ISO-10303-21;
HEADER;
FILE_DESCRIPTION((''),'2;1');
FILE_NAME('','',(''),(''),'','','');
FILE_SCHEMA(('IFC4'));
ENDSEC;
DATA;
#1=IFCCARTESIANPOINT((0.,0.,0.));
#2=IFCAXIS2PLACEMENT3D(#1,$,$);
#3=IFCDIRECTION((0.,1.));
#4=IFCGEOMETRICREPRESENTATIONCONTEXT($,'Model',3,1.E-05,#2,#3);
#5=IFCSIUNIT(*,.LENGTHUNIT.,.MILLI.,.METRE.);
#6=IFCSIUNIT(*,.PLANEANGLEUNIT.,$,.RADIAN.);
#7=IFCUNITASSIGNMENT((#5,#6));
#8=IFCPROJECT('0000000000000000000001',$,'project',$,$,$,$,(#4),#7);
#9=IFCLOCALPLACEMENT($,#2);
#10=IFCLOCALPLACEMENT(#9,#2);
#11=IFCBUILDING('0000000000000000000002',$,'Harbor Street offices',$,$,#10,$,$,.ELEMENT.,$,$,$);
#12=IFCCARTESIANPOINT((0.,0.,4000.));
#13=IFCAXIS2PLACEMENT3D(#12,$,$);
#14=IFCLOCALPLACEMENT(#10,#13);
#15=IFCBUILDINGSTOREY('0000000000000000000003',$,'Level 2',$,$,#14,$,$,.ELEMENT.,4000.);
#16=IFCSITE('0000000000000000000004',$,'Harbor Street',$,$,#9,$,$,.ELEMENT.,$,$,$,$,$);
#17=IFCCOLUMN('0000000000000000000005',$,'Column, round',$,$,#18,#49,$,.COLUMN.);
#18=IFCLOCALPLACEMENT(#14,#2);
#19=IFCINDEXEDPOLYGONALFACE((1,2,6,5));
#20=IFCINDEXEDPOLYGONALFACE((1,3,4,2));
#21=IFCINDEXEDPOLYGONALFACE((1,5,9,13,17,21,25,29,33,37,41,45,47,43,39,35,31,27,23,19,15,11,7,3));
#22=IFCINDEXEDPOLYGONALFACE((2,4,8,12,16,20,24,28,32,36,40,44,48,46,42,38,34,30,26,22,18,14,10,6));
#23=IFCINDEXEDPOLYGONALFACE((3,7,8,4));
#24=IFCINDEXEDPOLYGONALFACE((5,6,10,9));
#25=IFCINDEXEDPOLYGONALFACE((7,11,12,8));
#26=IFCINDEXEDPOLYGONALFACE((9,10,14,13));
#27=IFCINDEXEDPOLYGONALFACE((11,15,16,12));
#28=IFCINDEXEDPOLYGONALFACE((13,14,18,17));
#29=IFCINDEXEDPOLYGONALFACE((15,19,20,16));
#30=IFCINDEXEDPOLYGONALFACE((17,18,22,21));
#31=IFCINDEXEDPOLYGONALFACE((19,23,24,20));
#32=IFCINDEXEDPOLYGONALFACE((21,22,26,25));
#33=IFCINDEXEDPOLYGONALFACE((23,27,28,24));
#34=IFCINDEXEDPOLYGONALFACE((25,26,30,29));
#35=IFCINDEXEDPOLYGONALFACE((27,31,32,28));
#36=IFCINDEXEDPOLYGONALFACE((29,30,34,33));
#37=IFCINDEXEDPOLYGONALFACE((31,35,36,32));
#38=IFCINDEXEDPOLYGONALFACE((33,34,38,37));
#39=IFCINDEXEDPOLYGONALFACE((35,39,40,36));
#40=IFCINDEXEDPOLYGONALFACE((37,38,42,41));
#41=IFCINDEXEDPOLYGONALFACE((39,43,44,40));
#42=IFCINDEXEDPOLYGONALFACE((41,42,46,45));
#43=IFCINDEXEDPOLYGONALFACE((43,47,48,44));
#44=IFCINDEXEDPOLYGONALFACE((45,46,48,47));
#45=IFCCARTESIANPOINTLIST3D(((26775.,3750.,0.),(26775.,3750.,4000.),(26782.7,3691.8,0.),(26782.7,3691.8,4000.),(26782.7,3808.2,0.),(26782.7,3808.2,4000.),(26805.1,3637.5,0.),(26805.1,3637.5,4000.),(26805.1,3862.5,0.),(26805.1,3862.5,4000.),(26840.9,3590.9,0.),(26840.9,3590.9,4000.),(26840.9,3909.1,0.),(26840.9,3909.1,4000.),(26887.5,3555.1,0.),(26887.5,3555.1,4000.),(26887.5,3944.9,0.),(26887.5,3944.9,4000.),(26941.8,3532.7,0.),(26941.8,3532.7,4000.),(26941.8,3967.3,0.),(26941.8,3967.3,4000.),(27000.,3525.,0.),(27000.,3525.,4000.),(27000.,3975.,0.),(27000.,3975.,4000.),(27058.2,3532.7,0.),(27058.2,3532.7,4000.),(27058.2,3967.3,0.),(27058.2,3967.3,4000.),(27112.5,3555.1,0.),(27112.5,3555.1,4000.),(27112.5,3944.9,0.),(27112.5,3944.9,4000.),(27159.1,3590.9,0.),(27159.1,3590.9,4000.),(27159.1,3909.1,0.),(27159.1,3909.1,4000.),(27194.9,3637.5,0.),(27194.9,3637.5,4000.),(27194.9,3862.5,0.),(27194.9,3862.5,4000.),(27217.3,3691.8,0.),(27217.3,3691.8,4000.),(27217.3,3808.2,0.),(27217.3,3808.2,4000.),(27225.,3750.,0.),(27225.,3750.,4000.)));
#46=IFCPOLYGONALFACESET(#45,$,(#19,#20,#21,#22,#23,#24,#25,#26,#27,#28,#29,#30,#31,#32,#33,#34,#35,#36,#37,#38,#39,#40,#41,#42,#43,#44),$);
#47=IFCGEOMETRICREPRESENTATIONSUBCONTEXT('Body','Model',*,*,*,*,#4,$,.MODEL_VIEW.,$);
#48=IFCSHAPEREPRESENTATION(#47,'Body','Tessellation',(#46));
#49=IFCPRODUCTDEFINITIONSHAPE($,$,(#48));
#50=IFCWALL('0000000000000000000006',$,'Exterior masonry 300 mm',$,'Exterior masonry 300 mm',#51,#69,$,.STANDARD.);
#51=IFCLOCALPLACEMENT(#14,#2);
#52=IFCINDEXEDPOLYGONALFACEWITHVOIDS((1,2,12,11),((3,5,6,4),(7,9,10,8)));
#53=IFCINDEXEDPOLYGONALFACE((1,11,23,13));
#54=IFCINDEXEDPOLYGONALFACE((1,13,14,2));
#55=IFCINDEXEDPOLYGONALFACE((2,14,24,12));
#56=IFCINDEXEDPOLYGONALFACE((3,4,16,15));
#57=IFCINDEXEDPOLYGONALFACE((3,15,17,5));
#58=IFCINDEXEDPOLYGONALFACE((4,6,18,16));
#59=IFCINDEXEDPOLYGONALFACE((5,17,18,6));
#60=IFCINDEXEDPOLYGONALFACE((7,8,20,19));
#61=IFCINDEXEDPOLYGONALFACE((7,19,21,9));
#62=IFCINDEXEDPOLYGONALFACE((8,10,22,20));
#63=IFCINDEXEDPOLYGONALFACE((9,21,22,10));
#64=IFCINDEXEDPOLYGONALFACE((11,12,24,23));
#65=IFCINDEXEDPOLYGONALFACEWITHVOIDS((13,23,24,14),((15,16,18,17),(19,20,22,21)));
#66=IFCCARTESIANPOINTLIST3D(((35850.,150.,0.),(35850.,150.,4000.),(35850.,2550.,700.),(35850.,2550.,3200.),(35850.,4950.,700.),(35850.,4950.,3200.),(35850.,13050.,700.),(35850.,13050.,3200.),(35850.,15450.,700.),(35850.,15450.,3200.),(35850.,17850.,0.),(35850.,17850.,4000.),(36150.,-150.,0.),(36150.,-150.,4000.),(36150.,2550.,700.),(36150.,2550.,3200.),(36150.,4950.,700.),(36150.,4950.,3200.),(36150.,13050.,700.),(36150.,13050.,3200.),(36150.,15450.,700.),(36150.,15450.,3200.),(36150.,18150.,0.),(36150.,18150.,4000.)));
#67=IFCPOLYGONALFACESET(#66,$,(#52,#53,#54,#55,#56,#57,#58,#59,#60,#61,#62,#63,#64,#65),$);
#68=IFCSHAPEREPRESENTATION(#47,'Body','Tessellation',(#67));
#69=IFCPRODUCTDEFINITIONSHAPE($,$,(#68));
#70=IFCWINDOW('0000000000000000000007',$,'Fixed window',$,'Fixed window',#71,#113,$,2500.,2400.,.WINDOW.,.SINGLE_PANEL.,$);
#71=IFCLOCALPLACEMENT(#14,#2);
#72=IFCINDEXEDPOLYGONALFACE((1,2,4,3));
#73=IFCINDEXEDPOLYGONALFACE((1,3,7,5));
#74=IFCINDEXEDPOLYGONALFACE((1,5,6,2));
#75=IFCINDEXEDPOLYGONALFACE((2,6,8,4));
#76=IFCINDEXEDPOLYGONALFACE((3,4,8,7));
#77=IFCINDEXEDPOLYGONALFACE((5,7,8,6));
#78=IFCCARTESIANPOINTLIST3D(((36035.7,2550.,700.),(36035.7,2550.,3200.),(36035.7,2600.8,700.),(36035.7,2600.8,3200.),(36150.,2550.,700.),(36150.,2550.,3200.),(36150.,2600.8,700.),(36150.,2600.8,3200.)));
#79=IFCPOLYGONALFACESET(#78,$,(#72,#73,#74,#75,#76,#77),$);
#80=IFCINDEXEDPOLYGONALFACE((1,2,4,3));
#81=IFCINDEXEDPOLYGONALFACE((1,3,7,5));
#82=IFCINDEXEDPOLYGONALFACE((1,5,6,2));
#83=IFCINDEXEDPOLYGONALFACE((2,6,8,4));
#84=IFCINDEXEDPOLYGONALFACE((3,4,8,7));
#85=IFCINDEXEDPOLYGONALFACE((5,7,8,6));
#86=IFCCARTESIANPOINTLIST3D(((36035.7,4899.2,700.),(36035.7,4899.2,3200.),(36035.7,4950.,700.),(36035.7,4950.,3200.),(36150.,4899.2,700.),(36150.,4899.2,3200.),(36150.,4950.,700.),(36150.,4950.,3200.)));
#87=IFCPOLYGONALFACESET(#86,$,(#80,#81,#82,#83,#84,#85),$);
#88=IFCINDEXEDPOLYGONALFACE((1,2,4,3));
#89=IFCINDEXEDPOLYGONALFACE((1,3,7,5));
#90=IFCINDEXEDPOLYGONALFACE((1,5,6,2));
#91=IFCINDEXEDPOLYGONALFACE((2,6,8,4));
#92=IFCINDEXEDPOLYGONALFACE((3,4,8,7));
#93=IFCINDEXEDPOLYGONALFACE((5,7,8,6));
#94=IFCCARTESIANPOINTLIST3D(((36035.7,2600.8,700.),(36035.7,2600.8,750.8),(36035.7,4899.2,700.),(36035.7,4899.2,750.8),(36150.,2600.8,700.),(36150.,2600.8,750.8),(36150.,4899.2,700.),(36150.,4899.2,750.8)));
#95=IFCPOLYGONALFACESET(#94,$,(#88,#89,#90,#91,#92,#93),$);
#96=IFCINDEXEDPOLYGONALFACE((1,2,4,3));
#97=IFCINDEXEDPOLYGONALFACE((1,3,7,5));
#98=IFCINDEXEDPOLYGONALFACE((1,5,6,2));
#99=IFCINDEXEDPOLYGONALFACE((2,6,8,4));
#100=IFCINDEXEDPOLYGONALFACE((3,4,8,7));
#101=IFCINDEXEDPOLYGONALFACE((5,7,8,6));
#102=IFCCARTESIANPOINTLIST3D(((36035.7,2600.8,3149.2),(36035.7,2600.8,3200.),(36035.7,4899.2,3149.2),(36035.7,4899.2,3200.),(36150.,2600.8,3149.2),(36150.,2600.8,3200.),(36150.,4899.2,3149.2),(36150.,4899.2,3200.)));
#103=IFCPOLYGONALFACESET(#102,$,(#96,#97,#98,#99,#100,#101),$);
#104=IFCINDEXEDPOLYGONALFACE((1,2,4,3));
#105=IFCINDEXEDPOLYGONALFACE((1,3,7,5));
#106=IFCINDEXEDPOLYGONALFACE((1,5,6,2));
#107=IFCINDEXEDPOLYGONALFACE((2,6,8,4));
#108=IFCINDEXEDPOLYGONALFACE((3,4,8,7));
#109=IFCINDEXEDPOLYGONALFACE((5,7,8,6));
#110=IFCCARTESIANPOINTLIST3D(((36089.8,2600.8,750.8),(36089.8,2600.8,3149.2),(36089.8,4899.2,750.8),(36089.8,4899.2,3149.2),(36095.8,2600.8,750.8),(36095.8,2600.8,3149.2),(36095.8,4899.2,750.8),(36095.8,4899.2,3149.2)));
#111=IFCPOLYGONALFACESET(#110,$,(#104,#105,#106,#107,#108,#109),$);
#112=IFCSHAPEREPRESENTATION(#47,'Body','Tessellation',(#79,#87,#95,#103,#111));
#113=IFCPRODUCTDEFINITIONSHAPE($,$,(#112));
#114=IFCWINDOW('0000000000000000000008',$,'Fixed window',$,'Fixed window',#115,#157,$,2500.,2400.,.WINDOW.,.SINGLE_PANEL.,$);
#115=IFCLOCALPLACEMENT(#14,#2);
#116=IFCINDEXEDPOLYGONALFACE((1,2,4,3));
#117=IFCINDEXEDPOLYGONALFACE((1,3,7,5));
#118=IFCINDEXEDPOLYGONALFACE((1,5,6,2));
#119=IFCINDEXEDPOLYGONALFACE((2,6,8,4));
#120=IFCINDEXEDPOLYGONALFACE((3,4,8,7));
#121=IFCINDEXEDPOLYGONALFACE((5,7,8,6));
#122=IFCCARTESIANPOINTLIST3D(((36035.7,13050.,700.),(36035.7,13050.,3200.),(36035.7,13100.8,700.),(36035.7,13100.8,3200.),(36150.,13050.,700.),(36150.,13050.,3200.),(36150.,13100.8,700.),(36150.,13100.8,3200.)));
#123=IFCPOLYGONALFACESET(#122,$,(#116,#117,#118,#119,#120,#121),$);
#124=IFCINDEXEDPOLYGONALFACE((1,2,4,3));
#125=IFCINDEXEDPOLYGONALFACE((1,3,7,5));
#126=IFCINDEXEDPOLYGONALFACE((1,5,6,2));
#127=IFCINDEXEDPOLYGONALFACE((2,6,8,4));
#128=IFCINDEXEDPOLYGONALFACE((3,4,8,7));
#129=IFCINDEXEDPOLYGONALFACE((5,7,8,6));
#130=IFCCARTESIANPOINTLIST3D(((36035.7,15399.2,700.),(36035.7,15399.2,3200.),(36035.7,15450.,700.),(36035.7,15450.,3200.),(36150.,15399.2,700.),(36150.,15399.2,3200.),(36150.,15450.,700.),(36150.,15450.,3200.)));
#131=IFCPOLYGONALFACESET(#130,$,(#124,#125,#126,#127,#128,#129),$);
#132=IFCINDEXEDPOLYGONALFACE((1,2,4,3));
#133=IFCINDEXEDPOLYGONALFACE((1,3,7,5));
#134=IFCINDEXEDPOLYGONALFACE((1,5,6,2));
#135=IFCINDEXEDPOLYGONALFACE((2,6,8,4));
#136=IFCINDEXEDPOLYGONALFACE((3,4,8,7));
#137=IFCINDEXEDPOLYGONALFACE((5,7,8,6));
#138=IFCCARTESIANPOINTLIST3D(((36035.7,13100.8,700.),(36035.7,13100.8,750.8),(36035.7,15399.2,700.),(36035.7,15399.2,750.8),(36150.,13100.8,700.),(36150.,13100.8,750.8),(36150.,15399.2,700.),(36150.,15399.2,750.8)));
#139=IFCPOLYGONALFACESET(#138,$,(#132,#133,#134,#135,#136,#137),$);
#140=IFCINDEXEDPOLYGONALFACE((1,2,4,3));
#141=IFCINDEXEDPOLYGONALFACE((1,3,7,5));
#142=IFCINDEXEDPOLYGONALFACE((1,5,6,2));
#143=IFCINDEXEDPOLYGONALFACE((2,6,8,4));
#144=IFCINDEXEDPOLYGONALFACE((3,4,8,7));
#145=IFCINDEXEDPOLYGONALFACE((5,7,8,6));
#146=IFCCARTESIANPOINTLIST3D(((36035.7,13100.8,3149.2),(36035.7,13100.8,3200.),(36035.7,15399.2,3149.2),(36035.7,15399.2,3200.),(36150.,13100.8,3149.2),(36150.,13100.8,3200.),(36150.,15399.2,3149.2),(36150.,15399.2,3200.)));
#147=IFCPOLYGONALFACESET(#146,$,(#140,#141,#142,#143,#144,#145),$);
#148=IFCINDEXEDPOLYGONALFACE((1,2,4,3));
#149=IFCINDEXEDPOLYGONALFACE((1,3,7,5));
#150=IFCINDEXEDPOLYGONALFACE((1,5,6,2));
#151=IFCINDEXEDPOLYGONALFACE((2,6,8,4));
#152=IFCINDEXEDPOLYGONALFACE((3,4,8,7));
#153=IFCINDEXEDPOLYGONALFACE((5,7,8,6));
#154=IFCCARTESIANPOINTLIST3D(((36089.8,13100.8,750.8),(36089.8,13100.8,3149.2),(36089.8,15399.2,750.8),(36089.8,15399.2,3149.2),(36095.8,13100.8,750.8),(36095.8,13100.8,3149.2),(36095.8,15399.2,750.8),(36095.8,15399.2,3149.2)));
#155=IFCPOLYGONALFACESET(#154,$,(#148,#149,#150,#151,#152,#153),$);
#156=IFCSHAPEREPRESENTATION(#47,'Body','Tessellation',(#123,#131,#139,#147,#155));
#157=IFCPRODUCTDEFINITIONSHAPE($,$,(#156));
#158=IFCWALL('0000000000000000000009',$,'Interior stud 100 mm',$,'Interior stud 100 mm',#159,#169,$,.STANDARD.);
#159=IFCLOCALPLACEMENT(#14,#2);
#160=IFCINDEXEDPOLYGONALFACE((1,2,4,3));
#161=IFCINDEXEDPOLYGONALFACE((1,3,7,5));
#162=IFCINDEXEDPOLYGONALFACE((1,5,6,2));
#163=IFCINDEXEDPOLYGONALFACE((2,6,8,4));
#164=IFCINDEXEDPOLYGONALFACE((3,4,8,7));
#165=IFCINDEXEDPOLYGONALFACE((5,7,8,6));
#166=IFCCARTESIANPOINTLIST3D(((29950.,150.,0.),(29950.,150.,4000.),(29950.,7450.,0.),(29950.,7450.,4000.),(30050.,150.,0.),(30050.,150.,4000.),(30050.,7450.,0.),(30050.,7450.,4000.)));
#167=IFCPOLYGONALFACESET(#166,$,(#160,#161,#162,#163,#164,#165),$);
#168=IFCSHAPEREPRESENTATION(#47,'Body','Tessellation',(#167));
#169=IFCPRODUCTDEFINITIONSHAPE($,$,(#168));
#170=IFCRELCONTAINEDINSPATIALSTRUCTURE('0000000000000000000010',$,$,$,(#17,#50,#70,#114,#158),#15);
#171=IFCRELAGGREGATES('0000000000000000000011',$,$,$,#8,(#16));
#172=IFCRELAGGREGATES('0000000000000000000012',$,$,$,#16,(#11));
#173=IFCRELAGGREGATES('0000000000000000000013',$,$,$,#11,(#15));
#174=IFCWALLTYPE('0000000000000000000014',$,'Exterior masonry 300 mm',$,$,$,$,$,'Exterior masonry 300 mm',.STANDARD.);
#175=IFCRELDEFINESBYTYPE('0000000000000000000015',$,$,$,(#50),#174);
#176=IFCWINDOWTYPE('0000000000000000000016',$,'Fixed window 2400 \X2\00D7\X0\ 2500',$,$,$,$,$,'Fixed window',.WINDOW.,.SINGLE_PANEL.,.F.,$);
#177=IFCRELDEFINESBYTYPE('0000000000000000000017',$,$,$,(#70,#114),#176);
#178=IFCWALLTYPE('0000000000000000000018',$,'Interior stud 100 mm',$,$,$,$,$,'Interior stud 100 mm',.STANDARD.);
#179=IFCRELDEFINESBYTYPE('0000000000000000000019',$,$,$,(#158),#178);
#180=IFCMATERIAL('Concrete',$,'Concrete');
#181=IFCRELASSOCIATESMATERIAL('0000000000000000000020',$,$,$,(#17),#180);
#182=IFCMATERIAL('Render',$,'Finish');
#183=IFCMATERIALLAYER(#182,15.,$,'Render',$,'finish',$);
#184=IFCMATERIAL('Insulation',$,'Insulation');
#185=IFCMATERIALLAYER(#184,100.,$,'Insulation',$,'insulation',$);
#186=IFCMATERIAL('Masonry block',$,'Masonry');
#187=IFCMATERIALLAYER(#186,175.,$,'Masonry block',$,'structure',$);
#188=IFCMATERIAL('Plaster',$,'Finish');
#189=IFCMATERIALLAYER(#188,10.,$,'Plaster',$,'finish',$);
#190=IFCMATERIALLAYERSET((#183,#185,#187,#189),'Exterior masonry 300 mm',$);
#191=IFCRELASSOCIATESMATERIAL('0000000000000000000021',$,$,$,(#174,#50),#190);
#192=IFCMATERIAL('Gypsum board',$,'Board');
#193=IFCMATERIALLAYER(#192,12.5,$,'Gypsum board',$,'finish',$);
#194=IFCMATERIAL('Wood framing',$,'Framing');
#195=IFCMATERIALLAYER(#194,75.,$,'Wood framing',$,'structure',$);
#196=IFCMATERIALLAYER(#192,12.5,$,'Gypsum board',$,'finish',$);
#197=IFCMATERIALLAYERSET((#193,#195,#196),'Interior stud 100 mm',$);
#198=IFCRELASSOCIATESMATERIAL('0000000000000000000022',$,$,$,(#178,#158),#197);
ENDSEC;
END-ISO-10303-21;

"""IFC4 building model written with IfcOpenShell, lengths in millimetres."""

from ifc_helpers import new_model, si_unit, direction, frame, origin, origin_with_axes, origin_2d, place, context, subcontext, project, spatial, polyline, circle, outline, extrude, material, layer, layer_set, layer_usage, type_object, element, fill, save


model = new_model("IFC4")

# Units and contexts
model_context = context("Model", 3, precision=1e-05, world=origin(), true_north=direction((0.0, 1.0)))
body_context = subcontext(model_context, "Body", "Model", "MODEL_VIEW")
ifc_project = project(units=[si_unit("LENGTHUNIT", "METRE", prefix="MILLI"), si_unit("PLANEANGLEUNIT", "RADIAN")], contexts=[model_context])

# Site, building, storey
site_placement = place(None, origin())
site = spatial("IfcSite", under=ifc_project, at=site_placement, Name="Harbor Street", CompositionType="ELEMENT")
building_placement = place(site_placement, origin())
building = spatial("IfcBuilding", under=site, at=building_placement, Name="Harbor Street offices", CompositionType="ELEMENT")
storey_placement = place(building_placement, frame((0.0, 0.0, 4000.0)))
storey = spatial("IfcBuildingStorey", under=building, at=storey_placement, Name="Level 2", CompositionType="ELEMENT", Elevation=4000.0)

# Column
ifc_material_1 = material(Name="Concrete", Category="Concrete")
column_placement = place(storey_placement, frame((27000.0, 3750.0, 0.0), z_axis=(0.0, 0.0, 1.0), x_axis=(1.0, 0.0, 0.0)))
element("IfcColumn", 1, at=column_placement, inside=storey, material=ifc_material_1, Name="Column, round", PredefinedType="COLUMN", context=body_context, shape_type="SweptSolid", body=[
    extrude(circle(Radius=225.0, at=origin_2d()), origin(), (0.0, 0.0, 1.0), 4000.0),
])

# Wall, openings, windows
ifc_material_2 = material(Name="Render", Category="Finish")
ifc_layer_1 = layer(ifc_material_2, 15.0, Name="Render", Category="finish")
ifc_material_3 = material(Name="Insulation", Category="Insulation")
ifc_layer_2 = layer(ifc_material_3, 100.0, Name="Insulation", Category="insulation")
ifc_material_4 = material(Name="Masonry block", Category="Masonry")
ifc_layer_3 = layer(ifc_material_4, 175.0, Name="Masonry block", Category="structure")
ifc_material_5 = material(Name="Plaster", Category="Finish")
ifc_layer_4 = layer(ifc_material_5, 10.0, Name="Plaster", Category="finish")
ifc_layer_set_1 = layer_set([ifc_layer_1, ifc_layer_2, ifc_layer_3, ifc_layer_4], Name="Exterior masonry 300 mm")
ifc_layer_usage_1 = layer_usage(ifc_layer_set_1, "AXIS2", "POSITIVE", -150.0)
wall_type_1 = type_object("IfcWallType", Name="Exterior masonry 300 mm", ElementType="Exterior masonry 300 mm", PredefinedType="STANDARD", material=ifc_layer_set_1)
wall_1_placement = place(storey_placement, frame((36000.0, 0.0, 0.0), z_axis=(0.0, 0.0, 1.0), x_axis=(0.0, 1.0, 0.0)))
wall_1 = element("IfcWall", 2, at=wall_1_placement, inside=storey, type_object=wall_type_1, material=ifc_layer_usage_1, Name="Exterior masonry 300 mm", ObjectType="Exterior masonry 300 mm", PredefinedType="STANDARD", context=body_context, shape_type="SweptSolid", body=[
    extrude(outline(polyline([(-150.0, -150.0), (18150.0, -150.0), (17850.0, 150.0), (150.0, 150.0), (-150.0, -150.0)])), origin(), (0.0, 0.0, 1.0), 4000.0),
])
opening_1_placement = place(wall_1_placement, frame((2550.0, 0.0, 700.0), z_axis=(0.0, 0.0, 1.0), x_axis=(1.0, 0.0, 0.0)))
opening_1 = element("IfcOpeningElement", 3, at=opening_1_placement, cuts=wall_1, PredefinedType="OPENING", context=body_context, shape_type="SweptSolid", body=[
    extrude(outline(polyline([(0.0, -160.0), (2400.0, -160.0), (2400.0, 160.0), (0.0, 160.0), (0.0, -160.0)])), origin(), (0.0, 0.0, 1.0), 2500.0),
])
opening_2_placement = place(wall_1_placement, frame((13050.0, 0.0, 700.0), z_axis=(0.0, 0.0, 1.0), x_axis=(1.0, 0.0, 0.0)))
opening_2 = element("IfcOpeningElement", 4, at=opening_2_placement, cuts=wall_1, PredefinedType="OPENING", context=body_context, shape_type="SweptSolid", body=[
    extrude(outline(polyline([(0.0, -160.0), (2400.0, -160.0), (2400.0, 160.0), (0.0, 160.0), (0.0, -160.0)])), origin(), (0.0, 0.0, 1.0), 2500.0),
])
window_type = type_object("IfcWindowType", Name="Fixed window 2400 × 2500", ElementType="Fixed window", ParameterTakesPrecedence=False, PartitioningType="SINGLE_PANEL", PredefinedType="WINDOW")
window_1_placement = place(opening_1_placement, origin_with_axes())
window_1 = element("IfcWindow", 5, at=window_1_placement, inside=storey, type_object=window_type, Name="Fixed window", ObjectType="Fixed window", OverallHeight=2500.0, OverallWidth=2400.0, PartitioningType="SINGLE_PANEL", PredefinedType="WINDOW", context=body_context, shape_type="SweptSolid", body=[
    extrude(outline(polyline([(0.0, -150.0), (50.8, -150.0), (50.8, -35.7), (0.0, -35.7), (0.0, -150.0)])), origin(), (0.0, 0.0, 1.0), 2500.0),
    extrude(outline(polyline([(2349.2, -150.0), (2400.0, -150.0), (2400.0, -35.7), (2349.2, -35.7), (2349.2, -150.0)])), origin(), (0.0, 0.0, 1.0), 2500.0),
    extrude(outline(polyline([(50.8, -150.0), (2349.2, -150.0), (2349.2, -35.7), (50.8, -35.7), (50.8, -150.0)])), origin(), (0.0, 0.0, 1.0), 50.8),
    extrude(outline(polyline([(50.8, -150.0), (2349.2, -150.0), (2349.2, -35.7), (50.8, -35.7), (50.8, -150.0)])), frame((0.0, 0.0, 2449.2)), (0.0, 0.0, 1.0), 50.8),
    extrude(outline(polyline([(50.8, -95.8), (2349.2, -95.8), (2349.2, -89.8), (50.8, -89.8), (50.8, -95.8)])), frame((0.0, 0.0, 50.8)), (0.0, 0.0, 1.0), 2398.4),
])
fill(opening_1, window_1)
window_2_placement = place(opening_2_placement, origin_with_axes())
window_2 = element("IfcWindow", 6, at=window_2_placement, inside=storey, type_object=window_type, Name="Fixed window", ObjectType="Fixed window", OverallHeight=2500.0, OverallWidth=2400.0, PartitioningType="SINGLE_PANEL", PredefinedType="WINDOW", context=body_context, shape_type="SweptSolid", body=[
    extrude(outline(polyline([(0.0, -150.0), (50.8, -150.0), (50.8, -35.7), (0.0, -35.7), (0.0, -150.0)])), origin(), (0.0, 0.0, 1.0), 2500.0),
    extrude(outline(polyline([(2349.2, -150.0), (2400.0, -150.0), (2400.0, -35.7), (2349.2, -35.7), (2349.2, -150.0)])), origin(), (0.0, 0.0, 1.0), 2500.0),
    extrude(outline(polyline([(50.8, -150.0), (2349.2, -150.0), (2349.2, -35.7), (50.8, -35.7), (50.8, -150.0)])), origin(), (0.0, 0.0, 1.0), 50.8),
    extrude(outline(polyline([(50.8, -150.0), (2349.2, -150.0), (2349.2, -35.7), (50.8, -35.7), (50.8, -150.0)])), frame((0.0, 0.0, 2449.2)), (0.0, 0.0, 1.0), 50.8),
    extrude(outline(polyline([(50.8, -95.8), (2349.2, -95.8), (2349.2, -89.8), (50.8, -89.8), (50.8, -95.8)])), frame((0.0, 0.0, 50.8)), (0.0, 0.0, 1.0), 2398.4),
])
fill(opening_2, window_2)

# Wall
ifc_material_6 = material(Name="Gypsum board", Category="Board")
ifc_layer_5 = layer(ifc_material_6, 12.5, Name="Gypsum board", Category="finish")
ifc_material_7 = material(Name="Wood framing", Category="Framing")
ifc_layer_6 = layer(ifc_material_7, 75.0, Name="Wood framing", Category="structure")
ifc_layer_7 = layer(ifc_material_6, 12.5, Name="Gypsum board", Category="finish")
ifc_layer_set_2 = layer_set([ifc_layer_5, ifc_layer_6, ifc_layer_7], Name="Interior stud 100 mm")
ifc_layer_usage_2 = layer_usage(ifc_layer_set_2, "AXIS2", "NEGATIVE", 50.0)
wall_type_2 = type_object("IfcWallType", Name="Interior stud 100 mm", ElementType="Interior stud 100 mm", PredefinedType="STANDARD", material=ifc_layer_set_2)
wall_2_placement = place(storey_placement, frame((30000.0, 0.0, 0.0), z_axis=(0.0, 0.0, 1.0), x_axis=(0.0, 1.0, 0.0)))
element("IfcWall", 7, at=wall_2_placement, inside=storey, type_object=wall_type_2, material=ifc_layer_usage_2, Name="Interior stud 100 mm", ObjectType="Interior stud 100 mm", PredefinedType="STANDARD", context=body_context, shape_type="SweptSolid", body=[
    extrude(outline(polyline([(150.0, -50.0), (7450.0, -50.0), (7450.0, 50.0), (150.0, 50.0), (150.0, -50.0)])), origin(), (0.0, 0.0, 1.0), 4000.0),
])

save(model, "model.ifc")
